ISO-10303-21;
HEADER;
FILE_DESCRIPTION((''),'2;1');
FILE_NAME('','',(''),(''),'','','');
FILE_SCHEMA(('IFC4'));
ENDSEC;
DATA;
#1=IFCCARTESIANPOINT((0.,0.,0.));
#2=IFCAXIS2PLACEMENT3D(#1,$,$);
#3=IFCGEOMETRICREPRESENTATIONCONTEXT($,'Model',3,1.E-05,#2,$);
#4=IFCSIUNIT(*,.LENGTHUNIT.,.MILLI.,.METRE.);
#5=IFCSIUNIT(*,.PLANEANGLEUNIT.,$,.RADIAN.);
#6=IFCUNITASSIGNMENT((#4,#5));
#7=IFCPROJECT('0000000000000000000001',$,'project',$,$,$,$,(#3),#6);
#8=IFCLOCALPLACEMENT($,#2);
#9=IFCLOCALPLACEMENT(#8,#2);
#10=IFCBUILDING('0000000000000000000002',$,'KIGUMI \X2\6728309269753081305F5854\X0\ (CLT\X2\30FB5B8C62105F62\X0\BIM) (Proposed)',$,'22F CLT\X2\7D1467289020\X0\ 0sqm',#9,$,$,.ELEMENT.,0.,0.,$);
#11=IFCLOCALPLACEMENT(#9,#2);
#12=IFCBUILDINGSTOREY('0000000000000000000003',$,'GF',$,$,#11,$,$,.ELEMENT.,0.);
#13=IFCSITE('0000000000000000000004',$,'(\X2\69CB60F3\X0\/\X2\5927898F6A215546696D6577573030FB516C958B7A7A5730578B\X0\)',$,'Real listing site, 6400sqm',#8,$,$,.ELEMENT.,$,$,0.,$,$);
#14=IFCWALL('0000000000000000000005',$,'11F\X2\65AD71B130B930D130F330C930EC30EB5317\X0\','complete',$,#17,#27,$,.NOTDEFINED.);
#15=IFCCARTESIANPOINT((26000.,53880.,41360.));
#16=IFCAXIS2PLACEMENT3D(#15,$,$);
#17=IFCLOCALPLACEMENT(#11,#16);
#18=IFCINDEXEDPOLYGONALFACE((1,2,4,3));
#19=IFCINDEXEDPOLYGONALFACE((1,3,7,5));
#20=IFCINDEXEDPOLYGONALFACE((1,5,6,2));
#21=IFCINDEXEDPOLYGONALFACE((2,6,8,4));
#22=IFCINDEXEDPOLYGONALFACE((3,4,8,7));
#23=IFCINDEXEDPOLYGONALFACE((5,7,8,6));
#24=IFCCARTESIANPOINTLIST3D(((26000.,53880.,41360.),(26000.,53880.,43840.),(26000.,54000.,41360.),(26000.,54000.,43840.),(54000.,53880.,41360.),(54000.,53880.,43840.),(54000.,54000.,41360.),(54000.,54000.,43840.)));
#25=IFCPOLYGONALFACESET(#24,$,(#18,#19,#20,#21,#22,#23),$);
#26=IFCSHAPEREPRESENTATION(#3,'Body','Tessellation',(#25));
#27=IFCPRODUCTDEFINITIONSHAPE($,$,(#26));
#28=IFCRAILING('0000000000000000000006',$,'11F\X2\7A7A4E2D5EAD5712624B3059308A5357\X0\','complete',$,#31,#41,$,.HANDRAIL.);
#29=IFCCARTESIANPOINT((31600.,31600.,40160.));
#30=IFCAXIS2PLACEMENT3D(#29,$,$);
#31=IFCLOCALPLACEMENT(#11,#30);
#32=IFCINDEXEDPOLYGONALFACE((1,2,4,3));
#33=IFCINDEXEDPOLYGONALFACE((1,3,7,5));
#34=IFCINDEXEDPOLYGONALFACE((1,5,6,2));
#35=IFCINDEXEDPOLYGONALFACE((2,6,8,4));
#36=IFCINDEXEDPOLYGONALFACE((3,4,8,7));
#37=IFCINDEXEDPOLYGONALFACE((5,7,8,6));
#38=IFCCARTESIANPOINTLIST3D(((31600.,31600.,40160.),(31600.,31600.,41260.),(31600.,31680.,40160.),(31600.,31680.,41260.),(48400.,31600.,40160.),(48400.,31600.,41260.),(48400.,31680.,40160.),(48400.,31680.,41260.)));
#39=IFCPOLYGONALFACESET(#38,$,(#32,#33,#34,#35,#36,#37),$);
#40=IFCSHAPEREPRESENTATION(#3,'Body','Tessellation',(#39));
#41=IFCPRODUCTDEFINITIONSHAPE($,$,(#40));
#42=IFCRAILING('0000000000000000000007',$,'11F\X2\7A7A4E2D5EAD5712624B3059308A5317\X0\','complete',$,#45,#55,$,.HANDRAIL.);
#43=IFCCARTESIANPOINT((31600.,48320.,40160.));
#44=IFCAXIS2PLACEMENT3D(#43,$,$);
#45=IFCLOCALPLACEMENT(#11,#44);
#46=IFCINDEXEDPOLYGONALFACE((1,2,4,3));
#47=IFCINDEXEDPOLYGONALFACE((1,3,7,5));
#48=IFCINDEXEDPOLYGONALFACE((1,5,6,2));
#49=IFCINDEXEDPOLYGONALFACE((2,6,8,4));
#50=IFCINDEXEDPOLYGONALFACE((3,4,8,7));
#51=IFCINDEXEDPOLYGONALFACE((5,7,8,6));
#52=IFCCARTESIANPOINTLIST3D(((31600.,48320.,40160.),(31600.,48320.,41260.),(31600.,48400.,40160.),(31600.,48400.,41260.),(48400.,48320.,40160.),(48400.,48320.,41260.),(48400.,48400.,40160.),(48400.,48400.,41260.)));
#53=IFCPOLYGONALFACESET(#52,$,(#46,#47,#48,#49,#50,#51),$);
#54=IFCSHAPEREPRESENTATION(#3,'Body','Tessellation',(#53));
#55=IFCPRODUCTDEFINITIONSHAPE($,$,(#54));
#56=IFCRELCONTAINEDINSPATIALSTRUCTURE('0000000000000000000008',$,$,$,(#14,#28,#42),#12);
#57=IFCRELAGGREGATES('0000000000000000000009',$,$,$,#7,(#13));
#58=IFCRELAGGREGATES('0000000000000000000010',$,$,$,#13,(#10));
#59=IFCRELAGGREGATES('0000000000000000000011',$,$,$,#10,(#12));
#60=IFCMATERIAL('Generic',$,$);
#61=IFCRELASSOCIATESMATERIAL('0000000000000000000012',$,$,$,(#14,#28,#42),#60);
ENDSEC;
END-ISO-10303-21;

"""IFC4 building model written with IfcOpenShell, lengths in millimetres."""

from ifc_helpers import new_model, si_unit, frame, frame_2d, origin, place, context, project, spatial, rectangle, extrude, material, element, save


model = new_model("IFC4")

# Units and contexts
model_context = context("Model", 3, precision=1e-05, world=origin())
ifc_project = project(units=[si_unit("LENGTHUNIT", "METRE", prefix="MILLI"), si_unit("PLANEANGLEUNIT", "RADIAN")], contexts=[model_context])

# Site, building, storey
site_placement = place(None, origin())
site = spatial("IfcSite", under=ifc_project, at=site_placement, Name="(構想/大規模商業敷地・公開空地型)", ObjectType="Real listing site, 6400sqm", CompositionType="ELEMENT", RefElevation=0.0)
building_placement = place(site_placement, origin())
building = spatial("IfcBuilding", under=site, at=building_placement, Name="KIGUMI 木を極めた塔 (CLT・完成形BIM) (Proposed)", ObjectType="22F CLT純木造 0sqm", CompositionType="ELEMENT", ElevationOfRefHeight=0.0, ElevationOfTerrain=0.0)
storey_placement = place(building_placement, origin())
storey = spatial("IfcBuildingStorey", under=building, at=storey_placement, Name="GF", CompositionType="ELEMENT", Elevation=0.0)

# Shared definitions
ifc_material = material(Name="Generic")

# Wall
wall_1_placement = place(storey_placement, frame((26000.0, 53880.0, 41360.0)))
element("IfcWall", 1, at=wall_1_placement, inside=storey, material=ifc_material, Name="11F断熱スパンドレル北", Description="complete", PredefinedType="NOTDEFINED", context=model_context, shape_type="SweptSolid", body=[
    extrude(rectangle(XDim=28000.0, YDim=120.0, at=frame_2d((14000.0, 60.0))), frame((26000.0, 53880.0, 41360.0)), (0.0, 0.0, 1.0), 2480.0),
])

# Railings
railing_1_placement = place(storey_placement, frame((31600.0, 31600.0, 40160.0)))
element("IfcRailing", 2, at=railing_1_placement, inside=storey, material=ifc_material, Name="11F空中庭園手すり南", Description="complete", PredefinedType="HANDRAIL", context=model_context, shape_type="SweptSolid", body=[
    extrude(rectangle(XDim=16800.0, YDim=80.0, at=frame_2d((8400.0, 40.0))), frame((31600.0, 31600.0, 40160.0)), (0.0, 0.0, 1.0), 1100.0),
])
railing_2_placement = place(storey_placement, frame((31600.0, 48320.0, 40160.0)))
element("IfcRailing", 3, at=railing_2_placement, inside=storey, material=ifc_material, Name="11F空中庭園手すり北", Description="complete", PredefinedType="HANDRAIL", context=model_context, shape_type="SweptSolid", body=[
    extrude(rectangle(XDim=16800.0, YDim=80.0, at=frame_2d((8400.0, 40.0))), frame((31600.0, 48320.0, 40160.0)), (0.0, 0.0, 1.0), 1100.0),
])

save(model, "model.ifc")
